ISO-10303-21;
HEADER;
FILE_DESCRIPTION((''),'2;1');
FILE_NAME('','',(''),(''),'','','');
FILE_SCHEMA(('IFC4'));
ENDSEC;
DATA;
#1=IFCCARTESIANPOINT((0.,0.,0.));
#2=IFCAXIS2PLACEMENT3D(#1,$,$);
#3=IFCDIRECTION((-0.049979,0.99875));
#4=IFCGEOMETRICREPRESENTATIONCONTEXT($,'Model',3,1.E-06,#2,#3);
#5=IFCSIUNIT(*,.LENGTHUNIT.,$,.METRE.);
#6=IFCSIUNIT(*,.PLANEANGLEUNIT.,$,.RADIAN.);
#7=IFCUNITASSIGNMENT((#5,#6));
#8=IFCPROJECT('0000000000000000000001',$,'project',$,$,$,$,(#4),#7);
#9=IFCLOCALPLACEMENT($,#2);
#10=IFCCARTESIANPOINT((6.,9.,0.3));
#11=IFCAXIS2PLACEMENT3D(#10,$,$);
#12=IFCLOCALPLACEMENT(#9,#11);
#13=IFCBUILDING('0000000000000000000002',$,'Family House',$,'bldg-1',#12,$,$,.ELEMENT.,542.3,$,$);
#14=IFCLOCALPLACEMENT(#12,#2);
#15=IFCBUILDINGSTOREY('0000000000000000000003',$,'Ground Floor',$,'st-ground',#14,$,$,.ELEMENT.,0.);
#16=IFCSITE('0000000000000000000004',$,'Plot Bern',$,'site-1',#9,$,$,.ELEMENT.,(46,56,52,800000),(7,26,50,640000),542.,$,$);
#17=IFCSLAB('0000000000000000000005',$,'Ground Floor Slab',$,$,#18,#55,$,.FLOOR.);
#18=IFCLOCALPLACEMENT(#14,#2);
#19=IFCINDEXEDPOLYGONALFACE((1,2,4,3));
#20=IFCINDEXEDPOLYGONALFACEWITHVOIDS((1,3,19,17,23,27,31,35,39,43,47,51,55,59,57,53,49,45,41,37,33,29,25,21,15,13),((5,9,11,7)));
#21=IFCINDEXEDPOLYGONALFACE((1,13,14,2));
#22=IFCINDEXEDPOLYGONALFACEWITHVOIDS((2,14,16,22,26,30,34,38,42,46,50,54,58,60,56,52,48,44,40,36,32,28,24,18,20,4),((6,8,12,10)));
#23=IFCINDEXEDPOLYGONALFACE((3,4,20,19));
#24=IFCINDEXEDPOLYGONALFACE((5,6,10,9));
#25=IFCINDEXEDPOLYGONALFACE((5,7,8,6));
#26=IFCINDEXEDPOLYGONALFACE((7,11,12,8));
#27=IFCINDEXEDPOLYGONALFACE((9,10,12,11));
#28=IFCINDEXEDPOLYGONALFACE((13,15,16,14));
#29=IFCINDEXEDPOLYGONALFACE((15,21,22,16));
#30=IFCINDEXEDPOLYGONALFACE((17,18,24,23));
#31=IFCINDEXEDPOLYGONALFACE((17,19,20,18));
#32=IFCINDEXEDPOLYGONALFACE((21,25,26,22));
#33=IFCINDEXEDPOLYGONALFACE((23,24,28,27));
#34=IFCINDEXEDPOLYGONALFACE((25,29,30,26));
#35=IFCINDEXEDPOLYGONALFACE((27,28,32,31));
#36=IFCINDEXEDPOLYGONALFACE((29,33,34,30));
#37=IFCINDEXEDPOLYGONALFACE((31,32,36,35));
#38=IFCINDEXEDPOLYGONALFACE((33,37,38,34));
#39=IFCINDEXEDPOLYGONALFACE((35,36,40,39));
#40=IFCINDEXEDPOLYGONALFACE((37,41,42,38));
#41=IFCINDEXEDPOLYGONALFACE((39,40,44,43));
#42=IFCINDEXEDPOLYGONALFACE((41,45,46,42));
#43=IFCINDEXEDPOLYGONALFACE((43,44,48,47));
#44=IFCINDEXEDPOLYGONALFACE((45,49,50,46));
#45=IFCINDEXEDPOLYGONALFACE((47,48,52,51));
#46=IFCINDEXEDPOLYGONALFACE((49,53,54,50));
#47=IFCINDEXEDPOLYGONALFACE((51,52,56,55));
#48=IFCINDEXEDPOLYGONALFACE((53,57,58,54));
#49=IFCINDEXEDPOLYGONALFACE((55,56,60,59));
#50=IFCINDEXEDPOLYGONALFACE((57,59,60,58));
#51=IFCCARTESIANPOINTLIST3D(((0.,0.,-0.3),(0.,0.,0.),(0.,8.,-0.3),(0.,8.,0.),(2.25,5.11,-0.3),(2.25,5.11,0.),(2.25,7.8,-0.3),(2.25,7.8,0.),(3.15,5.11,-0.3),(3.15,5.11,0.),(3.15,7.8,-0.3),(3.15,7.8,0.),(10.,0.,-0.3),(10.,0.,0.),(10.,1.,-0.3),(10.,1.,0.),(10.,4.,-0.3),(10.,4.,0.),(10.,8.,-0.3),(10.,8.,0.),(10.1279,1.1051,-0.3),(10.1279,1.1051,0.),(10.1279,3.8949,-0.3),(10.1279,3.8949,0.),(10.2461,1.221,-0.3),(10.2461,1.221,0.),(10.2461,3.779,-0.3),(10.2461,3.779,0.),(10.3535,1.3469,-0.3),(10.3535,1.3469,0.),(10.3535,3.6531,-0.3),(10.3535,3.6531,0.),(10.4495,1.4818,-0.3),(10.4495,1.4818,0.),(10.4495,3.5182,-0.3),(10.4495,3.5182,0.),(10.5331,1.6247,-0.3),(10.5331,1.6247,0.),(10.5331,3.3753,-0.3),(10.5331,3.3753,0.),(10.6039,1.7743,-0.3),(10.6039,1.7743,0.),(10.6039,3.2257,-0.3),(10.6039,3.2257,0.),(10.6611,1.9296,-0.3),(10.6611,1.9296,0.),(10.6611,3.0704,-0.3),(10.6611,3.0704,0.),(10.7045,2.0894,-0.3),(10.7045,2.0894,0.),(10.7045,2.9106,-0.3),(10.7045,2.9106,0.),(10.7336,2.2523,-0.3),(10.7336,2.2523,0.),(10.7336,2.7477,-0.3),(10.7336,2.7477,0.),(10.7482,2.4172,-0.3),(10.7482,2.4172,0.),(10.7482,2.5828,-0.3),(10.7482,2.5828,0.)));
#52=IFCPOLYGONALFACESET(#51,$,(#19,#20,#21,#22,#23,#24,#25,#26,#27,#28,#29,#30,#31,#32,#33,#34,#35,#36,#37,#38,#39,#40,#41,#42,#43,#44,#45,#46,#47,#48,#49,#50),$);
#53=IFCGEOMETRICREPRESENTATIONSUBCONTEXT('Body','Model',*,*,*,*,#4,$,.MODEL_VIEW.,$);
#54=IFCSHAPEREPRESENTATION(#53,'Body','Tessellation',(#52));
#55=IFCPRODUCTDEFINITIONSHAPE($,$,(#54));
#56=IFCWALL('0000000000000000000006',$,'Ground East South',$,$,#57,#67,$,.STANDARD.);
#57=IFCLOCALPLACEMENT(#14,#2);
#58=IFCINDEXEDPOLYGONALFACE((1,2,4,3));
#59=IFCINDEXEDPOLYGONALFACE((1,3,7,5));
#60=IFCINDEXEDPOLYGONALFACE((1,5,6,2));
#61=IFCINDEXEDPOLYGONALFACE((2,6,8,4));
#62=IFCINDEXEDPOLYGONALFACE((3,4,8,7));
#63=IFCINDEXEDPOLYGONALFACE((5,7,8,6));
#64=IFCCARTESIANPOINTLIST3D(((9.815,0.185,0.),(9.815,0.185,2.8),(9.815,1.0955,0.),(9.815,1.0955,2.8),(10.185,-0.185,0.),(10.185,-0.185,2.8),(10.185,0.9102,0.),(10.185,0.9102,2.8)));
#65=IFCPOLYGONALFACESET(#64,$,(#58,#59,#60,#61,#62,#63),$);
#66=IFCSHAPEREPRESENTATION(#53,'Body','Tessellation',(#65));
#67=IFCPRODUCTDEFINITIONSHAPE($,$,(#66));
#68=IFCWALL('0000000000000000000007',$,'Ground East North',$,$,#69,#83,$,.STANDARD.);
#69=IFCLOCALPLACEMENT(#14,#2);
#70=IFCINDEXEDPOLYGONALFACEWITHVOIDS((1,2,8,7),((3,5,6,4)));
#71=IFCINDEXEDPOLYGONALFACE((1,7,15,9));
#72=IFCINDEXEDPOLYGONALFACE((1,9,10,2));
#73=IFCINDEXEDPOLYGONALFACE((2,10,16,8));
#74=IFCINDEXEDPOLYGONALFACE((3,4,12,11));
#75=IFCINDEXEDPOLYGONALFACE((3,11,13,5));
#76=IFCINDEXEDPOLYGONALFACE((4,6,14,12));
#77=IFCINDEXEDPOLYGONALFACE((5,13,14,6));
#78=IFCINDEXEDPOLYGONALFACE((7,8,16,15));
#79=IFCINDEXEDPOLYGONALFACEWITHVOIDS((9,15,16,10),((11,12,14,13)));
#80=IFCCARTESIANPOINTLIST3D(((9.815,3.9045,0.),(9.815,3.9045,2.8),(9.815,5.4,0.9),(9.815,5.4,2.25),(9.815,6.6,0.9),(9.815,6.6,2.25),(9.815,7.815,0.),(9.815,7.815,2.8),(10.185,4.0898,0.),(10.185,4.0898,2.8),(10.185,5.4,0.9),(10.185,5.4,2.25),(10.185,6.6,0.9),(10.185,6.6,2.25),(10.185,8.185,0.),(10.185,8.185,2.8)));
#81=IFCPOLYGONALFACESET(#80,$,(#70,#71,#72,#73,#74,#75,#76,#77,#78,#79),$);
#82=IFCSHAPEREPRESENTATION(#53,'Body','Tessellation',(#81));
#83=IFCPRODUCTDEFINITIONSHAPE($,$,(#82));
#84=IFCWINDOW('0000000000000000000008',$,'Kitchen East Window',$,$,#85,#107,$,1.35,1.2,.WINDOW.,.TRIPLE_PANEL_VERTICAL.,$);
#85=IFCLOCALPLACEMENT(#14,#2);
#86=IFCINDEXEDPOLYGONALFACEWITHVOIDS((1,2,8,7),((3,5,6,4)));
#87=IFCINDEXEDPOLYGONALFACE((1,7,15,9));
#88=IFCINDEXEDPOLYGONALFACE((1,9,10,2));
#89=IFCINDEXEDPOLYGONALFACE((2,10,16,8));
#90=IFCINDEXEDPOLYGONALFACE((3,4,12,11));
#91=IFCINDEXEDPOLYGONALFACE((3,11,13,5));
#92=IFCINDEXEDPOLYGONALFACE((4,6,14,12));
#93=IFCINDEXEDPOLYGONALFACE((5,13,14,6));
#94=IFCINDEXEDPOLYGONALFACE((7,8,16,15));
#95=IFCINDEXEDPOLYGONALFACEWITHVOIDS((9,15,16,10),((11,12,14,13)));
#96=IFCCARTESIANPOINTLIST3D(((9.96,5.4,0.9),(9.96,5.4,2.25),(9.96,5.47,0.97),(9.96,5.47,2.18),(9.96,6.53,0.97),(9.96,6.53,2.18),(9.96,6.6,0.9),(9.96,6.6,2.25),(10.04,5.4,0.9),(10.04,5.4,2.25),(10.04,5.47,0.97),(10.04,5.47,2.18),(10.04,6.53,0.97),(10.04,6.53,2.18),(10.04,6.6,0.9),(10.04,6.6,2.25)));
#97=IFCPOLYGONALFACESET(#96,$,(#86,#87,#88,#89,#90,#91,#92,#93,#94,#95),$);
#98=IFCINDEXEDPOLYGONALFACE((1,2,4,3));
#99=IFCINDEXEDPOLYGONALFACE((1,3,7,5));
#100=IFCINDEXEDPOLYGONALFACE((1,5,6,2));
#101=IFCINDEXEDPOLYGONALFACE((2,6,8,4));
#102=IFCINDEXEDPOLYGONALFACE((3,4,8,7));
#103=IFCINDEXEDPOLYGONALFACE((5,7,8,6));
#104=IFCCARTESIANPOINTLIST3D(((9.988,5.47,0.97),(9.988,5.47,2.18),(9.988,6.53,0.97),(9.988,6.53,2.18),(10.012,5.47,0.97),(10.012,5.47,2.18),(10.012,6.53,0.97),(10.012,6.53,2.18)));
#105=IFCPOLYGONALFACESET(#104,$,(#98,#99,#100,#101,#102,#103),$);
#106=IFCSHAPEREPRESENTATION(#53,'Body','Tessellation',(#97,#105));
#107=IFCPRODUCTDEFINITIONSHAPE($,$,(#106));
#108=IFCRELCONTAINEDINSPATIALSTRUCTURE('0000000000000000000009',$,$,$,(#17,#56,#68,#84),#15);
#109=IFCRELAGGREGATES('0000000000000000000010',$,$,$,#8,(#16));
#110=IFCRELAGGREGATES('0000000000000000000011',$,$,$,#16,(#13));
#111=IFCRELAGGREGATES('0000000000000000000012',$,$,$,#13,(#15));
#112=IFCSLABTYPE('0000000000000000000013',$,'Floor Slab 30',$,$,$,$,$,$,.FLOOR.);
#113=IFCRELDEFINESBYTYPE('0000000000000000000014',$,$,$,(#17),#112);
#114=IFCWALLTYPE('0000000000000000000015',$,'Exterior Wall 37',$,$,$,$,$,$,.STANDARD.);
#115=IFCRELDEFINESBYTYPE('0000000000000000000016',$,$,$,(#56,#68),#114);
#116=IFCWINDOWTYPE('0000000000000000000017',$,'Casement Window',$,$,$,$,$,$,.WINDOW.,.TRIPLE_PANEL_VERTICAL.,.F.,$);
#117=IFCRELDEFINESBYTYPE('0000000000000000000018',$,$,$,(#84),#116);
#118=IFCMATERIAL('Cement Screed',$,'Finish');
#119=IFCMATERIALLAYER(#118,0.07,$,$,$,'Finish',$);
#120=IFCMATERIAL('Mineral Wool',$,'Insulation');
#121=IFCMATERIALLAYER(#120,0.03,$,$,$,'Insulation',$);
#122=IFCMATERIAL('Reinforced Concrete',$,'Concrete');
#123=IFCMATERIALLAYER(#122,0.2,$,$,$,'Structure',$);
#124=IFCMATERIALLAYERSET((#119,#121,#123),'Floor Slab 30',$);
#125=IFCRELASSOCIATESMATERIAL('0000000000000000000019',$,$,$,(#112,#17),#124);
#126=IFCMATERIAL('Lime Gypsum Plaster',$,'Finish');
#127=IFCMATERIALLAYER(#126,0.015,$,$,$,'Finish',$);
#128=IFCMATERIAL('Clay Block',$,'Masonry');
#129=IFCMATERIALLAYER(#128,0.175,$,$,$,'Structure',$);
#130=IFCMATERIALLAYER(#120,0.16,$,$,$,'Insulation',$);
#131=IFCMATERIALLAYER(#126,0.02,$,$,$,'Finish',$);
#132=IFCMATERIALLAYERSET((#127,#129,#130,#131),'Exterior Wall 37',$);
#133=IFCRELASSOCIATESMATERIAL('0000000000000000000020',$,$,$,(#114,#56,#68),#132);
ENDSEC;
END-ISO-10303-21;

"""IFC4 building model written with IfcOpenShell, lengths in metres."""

from ifc_helpers import new_model, si_unit, point, direction, frame, frame_2d, origin, origin_2d, place, context, subcontext, project, spatial, polyline, circle_curve, trimmed, segment, composite_curve, rectangle, outline, extrude, material, layer, layer_set, layer_usage, type_object, element, fill, save


model = new_model("IFC4")

# Units and contexts
model_context = context("Model", 3, precision=1e-06, world=origin(), true_north=direction((-0.049979, 0.99875)))
body_context = subcontext(model_context, "Body", "Model", "MODEL_VIEW")
ifc_project = project(units=[si_unit("LENGTHUNIT", "METRE"), si_unit("PLANEANGLEUNIT", "RADIAN")], contexts=[model_context])

# Site, building, storey
site_placement = place(None, origin())
site = spatial("IfcSite", under=ifc_project, at=site_placement, Name="Plot Bern", ObjectType="site-1", CompositionType="ELEMENT", RefLatitude=(46, 56, 52, 800000), RefLongitude=(7, 26, 50, 640000), RefElevation=542.0)
building_placement = place(site_placement, frame((6.0, 9.0, 0.3)))
building = spatial("IfcBuilding", under=site, at=building_placement, Name="Family House", ObjectType="bldg-1", CompositionType="ELEMENT", ElevationOfRefHeight=542.3)
storey_placement = place(building_placement, origin())
storey = spatial("IfcBuildingStorey", under=building, at=storey_placement, Name="Ground Floor", ObjectType="st-ground", CompositionType="ELEMENT", Elevation=0.0)

# Slab
ifc_material_1 = material(Name="Cement Screed", Category="Finish")
ifc_layer_1 = layer(ifc_material_1, 0.07, Category="Finish")
ifc_material_2 = material(Name="Mineral Wool", Category="Insulation")
ifc_layer_2 = layer(ifc_material_2, 0.03, Category="Insulation")
ifc_material_3 = material(Name="Reinforced Concrete", Category="Concrete")
ifc_layer_3 = layer(ifc_material_3, 0.2, Category="Structure")
ifc_layer_set_1 = layer_set([ifc_layer_1, ifc_layer_2, ifc_layer_3], Name="Floor Slab 30")
ifc_layer_usage_1 = layer_usage(ifc_layer_set_1, "AXIS3", "NEGATIVE", 0.3)
slab_type = type_object("IfcSlabType", Name="Floor Slab 30", PredefinedType="FLOOR", material=ifc_layer_set_1)
slab_placement = place(storey_placement, frame((0.0, 0.0, -0.3)))
element("IfcSlab", 1, at=slab_placement, inside=storey, type_object=slab_type, material=ifc_layer_usage_1, Name="Ground Floor Slab", PredefinedType="FLOOR", context=body_context, shape_type="SweptSolid", body=[
    extrude(outline(composite_curve([segment(polyline([(0.0, 0.0), (10.0, 0.0)]), True, "CONTINUOUS"), segment(polyline([(10.0, 0.0), (10.0, 1.0)]), True, "CONTINUOUS"), segment(trimmed(circle_curve(frame_2d((8.875, 2.5)), 1.875), [point((10.0, 1.0))], [point((10.0, 4.0))], True, "CARTESIAN"), True, "CONTINUOUS"), segment(polyline([(10.0, 4.0), (10.0, 8.0)]), True, "CONTINUOUS"), segment(polyline([(10.0, 8.0), (0.0, 8.0)]), True, "CONTINUOUS"), segment(polyline([(0.0, 8.0), (0.0, 0.0)]), True, "CONTINUOUS")], self_intersect=False), holes=[polyline([(2.25, 5.11), (2.25, 7.8), (3.15, 7.8), (3.15, 5.11), (2.25, 5.11)])]), origin(), (0.0, 0.0, 1.0), 0.3),
])

# Shared definitions
ifc_material_4 = material(Name="Lime Gypsum Plaster", Category="Finish")
ifc_layer_4 = layer(ifc_material_4, 0.015, Category="Finish")
ifc_material_5 = material(Name="Clay Block", Category="Masonry")
ifc_layer_5 = layer(ifc_material_5, 0.175, Category="Structure")
ifc_layer_6 = layer(ifc_material_2, 0.16, Category="Insulation")
ifc_layer_7 = layer(ifc_material_4, 0.02, Category="Finish")
ifc_layer_set_2 = layer_set([ifc_layer_4, ifc_layer_5, ifc_layer_6, ifc_layer_7], Name="Exterior Wall 37")
wall_type_1 = type_object("IfcWallType", Name="Exterior Wall 37", PredefinedType="STANDARD", material=ifc_layer_set_2)

# Wall
ifc_layer_usage_2 = layer_usage(ifc_layer_set_2, "AXIS2", "NEGATIVE", 0.185)
wall_1_placement = place(storey_placement, origin())
element("IfcWall", 2, at=wall_1_placement, inside=storey, type_object=wall_type_1, material=ifc_layer_usage_2, Name="Ground East South", PredefinedType="STANDARD", context=body_context, shape_type="SweptSolid", body=[
    extrude(outline(polyline([(10.185, -0.185), (10.185, 0.9102), (9.815, 1.0955), (9.815, 0.185), (10.185, -0.185)])), origin(), (0.0, 0.0, 1.0), 2.8),
])

# Wall, opening, window
ifc_layer_usage_3 = layer_usage(ifc_layer_set_2, "AXIS2", "NEGATIVE", 0.185)
wall_2_placement = place(storey_placement, origin())
wall_2 = element("IfcWall", 3, at=wall_2_placement, inside=storey, type_object=wall_type_1, material=ifc_layer_usage_3, Name="Ground East North", PredefinedType="STANDARD", context=body_context, shape_type="SweptSolid", body=[
    extrude(outline(polyline([(10.185, 4.0898), (10.185, 8.185), (9.815, 7.815), (9.815, 3.9045), (10.185, 4.0898)])), origin(), (0.0, 0.0, 1.0), 2.8),
])
opening_1_placement = place(wall_2_placement, frame((10.0, 6.0, 0.9), z_axis=(0.0, 0.0, 1.0), x_axis=(0.0, 1.0, 0.0)))
opening_1 = element("IfcOpeningElement", 4, at=opening_1_placement, cuts=wall_2, PredefinedType="OPENING", context=body_context, shape_type="SweptSolid", body=[
    extrude(rectangle(XDim=1.2, YDim=0.37, at=origin_2d()), origin(), (0.0, 0.0, 1.0), 1.35),
])
window_type_1 = type_object("IfcWindowType", Name="Casement Window", ParameterTakesPrecedence=False, PartitioningType="TRIPLE_PANEL_VERTICAL", PredefinedType="WINDOW")
window_1_placement = place(opening_1_placement, frame((0.0, 0.0, 0.0), z_axis=(0.0, -1.0, 0.0), x_axis=(1.0, 0.0, 0.0)))
window_1 = element("IfcWindow", 5, at=window_1_placement, inside=storey, type_object=window_type_1, Name="Kitchen East Window", OverallHeight=1.35, OverallWidth=1.2, PartitioningType="TRIPLE_PANEL_VERTICAL", PredefinedType="WINDOW", context=body_context, shape_type="SweptSolid", body=[
    extrude(outline(polyline([(-0.6, 0.0), (0.6, 0.0), (0.6, 1.35), (-0.6, 1.35), (-0.6, 0.0)]), holes=[polyline([(-0.53, 0.07), (0.53, 0.07), (0.53, 1.28), (-0.53, 1.28), (-0.53, 0.07)])]), frame((0.0, 0.0, -0.04)), (0.0, 0.0, 1.0), 0.08),
    extrude(rectangle(XDim=1.06, YDim=1.21, at=frame_2d((0.0, 0.675))), frame((0.0, 0.0, -0.012)), (0.0, 0.0, 1.0), 0.024),
])
fill(opening_1, window_1)

save(model, "model.ifc")
